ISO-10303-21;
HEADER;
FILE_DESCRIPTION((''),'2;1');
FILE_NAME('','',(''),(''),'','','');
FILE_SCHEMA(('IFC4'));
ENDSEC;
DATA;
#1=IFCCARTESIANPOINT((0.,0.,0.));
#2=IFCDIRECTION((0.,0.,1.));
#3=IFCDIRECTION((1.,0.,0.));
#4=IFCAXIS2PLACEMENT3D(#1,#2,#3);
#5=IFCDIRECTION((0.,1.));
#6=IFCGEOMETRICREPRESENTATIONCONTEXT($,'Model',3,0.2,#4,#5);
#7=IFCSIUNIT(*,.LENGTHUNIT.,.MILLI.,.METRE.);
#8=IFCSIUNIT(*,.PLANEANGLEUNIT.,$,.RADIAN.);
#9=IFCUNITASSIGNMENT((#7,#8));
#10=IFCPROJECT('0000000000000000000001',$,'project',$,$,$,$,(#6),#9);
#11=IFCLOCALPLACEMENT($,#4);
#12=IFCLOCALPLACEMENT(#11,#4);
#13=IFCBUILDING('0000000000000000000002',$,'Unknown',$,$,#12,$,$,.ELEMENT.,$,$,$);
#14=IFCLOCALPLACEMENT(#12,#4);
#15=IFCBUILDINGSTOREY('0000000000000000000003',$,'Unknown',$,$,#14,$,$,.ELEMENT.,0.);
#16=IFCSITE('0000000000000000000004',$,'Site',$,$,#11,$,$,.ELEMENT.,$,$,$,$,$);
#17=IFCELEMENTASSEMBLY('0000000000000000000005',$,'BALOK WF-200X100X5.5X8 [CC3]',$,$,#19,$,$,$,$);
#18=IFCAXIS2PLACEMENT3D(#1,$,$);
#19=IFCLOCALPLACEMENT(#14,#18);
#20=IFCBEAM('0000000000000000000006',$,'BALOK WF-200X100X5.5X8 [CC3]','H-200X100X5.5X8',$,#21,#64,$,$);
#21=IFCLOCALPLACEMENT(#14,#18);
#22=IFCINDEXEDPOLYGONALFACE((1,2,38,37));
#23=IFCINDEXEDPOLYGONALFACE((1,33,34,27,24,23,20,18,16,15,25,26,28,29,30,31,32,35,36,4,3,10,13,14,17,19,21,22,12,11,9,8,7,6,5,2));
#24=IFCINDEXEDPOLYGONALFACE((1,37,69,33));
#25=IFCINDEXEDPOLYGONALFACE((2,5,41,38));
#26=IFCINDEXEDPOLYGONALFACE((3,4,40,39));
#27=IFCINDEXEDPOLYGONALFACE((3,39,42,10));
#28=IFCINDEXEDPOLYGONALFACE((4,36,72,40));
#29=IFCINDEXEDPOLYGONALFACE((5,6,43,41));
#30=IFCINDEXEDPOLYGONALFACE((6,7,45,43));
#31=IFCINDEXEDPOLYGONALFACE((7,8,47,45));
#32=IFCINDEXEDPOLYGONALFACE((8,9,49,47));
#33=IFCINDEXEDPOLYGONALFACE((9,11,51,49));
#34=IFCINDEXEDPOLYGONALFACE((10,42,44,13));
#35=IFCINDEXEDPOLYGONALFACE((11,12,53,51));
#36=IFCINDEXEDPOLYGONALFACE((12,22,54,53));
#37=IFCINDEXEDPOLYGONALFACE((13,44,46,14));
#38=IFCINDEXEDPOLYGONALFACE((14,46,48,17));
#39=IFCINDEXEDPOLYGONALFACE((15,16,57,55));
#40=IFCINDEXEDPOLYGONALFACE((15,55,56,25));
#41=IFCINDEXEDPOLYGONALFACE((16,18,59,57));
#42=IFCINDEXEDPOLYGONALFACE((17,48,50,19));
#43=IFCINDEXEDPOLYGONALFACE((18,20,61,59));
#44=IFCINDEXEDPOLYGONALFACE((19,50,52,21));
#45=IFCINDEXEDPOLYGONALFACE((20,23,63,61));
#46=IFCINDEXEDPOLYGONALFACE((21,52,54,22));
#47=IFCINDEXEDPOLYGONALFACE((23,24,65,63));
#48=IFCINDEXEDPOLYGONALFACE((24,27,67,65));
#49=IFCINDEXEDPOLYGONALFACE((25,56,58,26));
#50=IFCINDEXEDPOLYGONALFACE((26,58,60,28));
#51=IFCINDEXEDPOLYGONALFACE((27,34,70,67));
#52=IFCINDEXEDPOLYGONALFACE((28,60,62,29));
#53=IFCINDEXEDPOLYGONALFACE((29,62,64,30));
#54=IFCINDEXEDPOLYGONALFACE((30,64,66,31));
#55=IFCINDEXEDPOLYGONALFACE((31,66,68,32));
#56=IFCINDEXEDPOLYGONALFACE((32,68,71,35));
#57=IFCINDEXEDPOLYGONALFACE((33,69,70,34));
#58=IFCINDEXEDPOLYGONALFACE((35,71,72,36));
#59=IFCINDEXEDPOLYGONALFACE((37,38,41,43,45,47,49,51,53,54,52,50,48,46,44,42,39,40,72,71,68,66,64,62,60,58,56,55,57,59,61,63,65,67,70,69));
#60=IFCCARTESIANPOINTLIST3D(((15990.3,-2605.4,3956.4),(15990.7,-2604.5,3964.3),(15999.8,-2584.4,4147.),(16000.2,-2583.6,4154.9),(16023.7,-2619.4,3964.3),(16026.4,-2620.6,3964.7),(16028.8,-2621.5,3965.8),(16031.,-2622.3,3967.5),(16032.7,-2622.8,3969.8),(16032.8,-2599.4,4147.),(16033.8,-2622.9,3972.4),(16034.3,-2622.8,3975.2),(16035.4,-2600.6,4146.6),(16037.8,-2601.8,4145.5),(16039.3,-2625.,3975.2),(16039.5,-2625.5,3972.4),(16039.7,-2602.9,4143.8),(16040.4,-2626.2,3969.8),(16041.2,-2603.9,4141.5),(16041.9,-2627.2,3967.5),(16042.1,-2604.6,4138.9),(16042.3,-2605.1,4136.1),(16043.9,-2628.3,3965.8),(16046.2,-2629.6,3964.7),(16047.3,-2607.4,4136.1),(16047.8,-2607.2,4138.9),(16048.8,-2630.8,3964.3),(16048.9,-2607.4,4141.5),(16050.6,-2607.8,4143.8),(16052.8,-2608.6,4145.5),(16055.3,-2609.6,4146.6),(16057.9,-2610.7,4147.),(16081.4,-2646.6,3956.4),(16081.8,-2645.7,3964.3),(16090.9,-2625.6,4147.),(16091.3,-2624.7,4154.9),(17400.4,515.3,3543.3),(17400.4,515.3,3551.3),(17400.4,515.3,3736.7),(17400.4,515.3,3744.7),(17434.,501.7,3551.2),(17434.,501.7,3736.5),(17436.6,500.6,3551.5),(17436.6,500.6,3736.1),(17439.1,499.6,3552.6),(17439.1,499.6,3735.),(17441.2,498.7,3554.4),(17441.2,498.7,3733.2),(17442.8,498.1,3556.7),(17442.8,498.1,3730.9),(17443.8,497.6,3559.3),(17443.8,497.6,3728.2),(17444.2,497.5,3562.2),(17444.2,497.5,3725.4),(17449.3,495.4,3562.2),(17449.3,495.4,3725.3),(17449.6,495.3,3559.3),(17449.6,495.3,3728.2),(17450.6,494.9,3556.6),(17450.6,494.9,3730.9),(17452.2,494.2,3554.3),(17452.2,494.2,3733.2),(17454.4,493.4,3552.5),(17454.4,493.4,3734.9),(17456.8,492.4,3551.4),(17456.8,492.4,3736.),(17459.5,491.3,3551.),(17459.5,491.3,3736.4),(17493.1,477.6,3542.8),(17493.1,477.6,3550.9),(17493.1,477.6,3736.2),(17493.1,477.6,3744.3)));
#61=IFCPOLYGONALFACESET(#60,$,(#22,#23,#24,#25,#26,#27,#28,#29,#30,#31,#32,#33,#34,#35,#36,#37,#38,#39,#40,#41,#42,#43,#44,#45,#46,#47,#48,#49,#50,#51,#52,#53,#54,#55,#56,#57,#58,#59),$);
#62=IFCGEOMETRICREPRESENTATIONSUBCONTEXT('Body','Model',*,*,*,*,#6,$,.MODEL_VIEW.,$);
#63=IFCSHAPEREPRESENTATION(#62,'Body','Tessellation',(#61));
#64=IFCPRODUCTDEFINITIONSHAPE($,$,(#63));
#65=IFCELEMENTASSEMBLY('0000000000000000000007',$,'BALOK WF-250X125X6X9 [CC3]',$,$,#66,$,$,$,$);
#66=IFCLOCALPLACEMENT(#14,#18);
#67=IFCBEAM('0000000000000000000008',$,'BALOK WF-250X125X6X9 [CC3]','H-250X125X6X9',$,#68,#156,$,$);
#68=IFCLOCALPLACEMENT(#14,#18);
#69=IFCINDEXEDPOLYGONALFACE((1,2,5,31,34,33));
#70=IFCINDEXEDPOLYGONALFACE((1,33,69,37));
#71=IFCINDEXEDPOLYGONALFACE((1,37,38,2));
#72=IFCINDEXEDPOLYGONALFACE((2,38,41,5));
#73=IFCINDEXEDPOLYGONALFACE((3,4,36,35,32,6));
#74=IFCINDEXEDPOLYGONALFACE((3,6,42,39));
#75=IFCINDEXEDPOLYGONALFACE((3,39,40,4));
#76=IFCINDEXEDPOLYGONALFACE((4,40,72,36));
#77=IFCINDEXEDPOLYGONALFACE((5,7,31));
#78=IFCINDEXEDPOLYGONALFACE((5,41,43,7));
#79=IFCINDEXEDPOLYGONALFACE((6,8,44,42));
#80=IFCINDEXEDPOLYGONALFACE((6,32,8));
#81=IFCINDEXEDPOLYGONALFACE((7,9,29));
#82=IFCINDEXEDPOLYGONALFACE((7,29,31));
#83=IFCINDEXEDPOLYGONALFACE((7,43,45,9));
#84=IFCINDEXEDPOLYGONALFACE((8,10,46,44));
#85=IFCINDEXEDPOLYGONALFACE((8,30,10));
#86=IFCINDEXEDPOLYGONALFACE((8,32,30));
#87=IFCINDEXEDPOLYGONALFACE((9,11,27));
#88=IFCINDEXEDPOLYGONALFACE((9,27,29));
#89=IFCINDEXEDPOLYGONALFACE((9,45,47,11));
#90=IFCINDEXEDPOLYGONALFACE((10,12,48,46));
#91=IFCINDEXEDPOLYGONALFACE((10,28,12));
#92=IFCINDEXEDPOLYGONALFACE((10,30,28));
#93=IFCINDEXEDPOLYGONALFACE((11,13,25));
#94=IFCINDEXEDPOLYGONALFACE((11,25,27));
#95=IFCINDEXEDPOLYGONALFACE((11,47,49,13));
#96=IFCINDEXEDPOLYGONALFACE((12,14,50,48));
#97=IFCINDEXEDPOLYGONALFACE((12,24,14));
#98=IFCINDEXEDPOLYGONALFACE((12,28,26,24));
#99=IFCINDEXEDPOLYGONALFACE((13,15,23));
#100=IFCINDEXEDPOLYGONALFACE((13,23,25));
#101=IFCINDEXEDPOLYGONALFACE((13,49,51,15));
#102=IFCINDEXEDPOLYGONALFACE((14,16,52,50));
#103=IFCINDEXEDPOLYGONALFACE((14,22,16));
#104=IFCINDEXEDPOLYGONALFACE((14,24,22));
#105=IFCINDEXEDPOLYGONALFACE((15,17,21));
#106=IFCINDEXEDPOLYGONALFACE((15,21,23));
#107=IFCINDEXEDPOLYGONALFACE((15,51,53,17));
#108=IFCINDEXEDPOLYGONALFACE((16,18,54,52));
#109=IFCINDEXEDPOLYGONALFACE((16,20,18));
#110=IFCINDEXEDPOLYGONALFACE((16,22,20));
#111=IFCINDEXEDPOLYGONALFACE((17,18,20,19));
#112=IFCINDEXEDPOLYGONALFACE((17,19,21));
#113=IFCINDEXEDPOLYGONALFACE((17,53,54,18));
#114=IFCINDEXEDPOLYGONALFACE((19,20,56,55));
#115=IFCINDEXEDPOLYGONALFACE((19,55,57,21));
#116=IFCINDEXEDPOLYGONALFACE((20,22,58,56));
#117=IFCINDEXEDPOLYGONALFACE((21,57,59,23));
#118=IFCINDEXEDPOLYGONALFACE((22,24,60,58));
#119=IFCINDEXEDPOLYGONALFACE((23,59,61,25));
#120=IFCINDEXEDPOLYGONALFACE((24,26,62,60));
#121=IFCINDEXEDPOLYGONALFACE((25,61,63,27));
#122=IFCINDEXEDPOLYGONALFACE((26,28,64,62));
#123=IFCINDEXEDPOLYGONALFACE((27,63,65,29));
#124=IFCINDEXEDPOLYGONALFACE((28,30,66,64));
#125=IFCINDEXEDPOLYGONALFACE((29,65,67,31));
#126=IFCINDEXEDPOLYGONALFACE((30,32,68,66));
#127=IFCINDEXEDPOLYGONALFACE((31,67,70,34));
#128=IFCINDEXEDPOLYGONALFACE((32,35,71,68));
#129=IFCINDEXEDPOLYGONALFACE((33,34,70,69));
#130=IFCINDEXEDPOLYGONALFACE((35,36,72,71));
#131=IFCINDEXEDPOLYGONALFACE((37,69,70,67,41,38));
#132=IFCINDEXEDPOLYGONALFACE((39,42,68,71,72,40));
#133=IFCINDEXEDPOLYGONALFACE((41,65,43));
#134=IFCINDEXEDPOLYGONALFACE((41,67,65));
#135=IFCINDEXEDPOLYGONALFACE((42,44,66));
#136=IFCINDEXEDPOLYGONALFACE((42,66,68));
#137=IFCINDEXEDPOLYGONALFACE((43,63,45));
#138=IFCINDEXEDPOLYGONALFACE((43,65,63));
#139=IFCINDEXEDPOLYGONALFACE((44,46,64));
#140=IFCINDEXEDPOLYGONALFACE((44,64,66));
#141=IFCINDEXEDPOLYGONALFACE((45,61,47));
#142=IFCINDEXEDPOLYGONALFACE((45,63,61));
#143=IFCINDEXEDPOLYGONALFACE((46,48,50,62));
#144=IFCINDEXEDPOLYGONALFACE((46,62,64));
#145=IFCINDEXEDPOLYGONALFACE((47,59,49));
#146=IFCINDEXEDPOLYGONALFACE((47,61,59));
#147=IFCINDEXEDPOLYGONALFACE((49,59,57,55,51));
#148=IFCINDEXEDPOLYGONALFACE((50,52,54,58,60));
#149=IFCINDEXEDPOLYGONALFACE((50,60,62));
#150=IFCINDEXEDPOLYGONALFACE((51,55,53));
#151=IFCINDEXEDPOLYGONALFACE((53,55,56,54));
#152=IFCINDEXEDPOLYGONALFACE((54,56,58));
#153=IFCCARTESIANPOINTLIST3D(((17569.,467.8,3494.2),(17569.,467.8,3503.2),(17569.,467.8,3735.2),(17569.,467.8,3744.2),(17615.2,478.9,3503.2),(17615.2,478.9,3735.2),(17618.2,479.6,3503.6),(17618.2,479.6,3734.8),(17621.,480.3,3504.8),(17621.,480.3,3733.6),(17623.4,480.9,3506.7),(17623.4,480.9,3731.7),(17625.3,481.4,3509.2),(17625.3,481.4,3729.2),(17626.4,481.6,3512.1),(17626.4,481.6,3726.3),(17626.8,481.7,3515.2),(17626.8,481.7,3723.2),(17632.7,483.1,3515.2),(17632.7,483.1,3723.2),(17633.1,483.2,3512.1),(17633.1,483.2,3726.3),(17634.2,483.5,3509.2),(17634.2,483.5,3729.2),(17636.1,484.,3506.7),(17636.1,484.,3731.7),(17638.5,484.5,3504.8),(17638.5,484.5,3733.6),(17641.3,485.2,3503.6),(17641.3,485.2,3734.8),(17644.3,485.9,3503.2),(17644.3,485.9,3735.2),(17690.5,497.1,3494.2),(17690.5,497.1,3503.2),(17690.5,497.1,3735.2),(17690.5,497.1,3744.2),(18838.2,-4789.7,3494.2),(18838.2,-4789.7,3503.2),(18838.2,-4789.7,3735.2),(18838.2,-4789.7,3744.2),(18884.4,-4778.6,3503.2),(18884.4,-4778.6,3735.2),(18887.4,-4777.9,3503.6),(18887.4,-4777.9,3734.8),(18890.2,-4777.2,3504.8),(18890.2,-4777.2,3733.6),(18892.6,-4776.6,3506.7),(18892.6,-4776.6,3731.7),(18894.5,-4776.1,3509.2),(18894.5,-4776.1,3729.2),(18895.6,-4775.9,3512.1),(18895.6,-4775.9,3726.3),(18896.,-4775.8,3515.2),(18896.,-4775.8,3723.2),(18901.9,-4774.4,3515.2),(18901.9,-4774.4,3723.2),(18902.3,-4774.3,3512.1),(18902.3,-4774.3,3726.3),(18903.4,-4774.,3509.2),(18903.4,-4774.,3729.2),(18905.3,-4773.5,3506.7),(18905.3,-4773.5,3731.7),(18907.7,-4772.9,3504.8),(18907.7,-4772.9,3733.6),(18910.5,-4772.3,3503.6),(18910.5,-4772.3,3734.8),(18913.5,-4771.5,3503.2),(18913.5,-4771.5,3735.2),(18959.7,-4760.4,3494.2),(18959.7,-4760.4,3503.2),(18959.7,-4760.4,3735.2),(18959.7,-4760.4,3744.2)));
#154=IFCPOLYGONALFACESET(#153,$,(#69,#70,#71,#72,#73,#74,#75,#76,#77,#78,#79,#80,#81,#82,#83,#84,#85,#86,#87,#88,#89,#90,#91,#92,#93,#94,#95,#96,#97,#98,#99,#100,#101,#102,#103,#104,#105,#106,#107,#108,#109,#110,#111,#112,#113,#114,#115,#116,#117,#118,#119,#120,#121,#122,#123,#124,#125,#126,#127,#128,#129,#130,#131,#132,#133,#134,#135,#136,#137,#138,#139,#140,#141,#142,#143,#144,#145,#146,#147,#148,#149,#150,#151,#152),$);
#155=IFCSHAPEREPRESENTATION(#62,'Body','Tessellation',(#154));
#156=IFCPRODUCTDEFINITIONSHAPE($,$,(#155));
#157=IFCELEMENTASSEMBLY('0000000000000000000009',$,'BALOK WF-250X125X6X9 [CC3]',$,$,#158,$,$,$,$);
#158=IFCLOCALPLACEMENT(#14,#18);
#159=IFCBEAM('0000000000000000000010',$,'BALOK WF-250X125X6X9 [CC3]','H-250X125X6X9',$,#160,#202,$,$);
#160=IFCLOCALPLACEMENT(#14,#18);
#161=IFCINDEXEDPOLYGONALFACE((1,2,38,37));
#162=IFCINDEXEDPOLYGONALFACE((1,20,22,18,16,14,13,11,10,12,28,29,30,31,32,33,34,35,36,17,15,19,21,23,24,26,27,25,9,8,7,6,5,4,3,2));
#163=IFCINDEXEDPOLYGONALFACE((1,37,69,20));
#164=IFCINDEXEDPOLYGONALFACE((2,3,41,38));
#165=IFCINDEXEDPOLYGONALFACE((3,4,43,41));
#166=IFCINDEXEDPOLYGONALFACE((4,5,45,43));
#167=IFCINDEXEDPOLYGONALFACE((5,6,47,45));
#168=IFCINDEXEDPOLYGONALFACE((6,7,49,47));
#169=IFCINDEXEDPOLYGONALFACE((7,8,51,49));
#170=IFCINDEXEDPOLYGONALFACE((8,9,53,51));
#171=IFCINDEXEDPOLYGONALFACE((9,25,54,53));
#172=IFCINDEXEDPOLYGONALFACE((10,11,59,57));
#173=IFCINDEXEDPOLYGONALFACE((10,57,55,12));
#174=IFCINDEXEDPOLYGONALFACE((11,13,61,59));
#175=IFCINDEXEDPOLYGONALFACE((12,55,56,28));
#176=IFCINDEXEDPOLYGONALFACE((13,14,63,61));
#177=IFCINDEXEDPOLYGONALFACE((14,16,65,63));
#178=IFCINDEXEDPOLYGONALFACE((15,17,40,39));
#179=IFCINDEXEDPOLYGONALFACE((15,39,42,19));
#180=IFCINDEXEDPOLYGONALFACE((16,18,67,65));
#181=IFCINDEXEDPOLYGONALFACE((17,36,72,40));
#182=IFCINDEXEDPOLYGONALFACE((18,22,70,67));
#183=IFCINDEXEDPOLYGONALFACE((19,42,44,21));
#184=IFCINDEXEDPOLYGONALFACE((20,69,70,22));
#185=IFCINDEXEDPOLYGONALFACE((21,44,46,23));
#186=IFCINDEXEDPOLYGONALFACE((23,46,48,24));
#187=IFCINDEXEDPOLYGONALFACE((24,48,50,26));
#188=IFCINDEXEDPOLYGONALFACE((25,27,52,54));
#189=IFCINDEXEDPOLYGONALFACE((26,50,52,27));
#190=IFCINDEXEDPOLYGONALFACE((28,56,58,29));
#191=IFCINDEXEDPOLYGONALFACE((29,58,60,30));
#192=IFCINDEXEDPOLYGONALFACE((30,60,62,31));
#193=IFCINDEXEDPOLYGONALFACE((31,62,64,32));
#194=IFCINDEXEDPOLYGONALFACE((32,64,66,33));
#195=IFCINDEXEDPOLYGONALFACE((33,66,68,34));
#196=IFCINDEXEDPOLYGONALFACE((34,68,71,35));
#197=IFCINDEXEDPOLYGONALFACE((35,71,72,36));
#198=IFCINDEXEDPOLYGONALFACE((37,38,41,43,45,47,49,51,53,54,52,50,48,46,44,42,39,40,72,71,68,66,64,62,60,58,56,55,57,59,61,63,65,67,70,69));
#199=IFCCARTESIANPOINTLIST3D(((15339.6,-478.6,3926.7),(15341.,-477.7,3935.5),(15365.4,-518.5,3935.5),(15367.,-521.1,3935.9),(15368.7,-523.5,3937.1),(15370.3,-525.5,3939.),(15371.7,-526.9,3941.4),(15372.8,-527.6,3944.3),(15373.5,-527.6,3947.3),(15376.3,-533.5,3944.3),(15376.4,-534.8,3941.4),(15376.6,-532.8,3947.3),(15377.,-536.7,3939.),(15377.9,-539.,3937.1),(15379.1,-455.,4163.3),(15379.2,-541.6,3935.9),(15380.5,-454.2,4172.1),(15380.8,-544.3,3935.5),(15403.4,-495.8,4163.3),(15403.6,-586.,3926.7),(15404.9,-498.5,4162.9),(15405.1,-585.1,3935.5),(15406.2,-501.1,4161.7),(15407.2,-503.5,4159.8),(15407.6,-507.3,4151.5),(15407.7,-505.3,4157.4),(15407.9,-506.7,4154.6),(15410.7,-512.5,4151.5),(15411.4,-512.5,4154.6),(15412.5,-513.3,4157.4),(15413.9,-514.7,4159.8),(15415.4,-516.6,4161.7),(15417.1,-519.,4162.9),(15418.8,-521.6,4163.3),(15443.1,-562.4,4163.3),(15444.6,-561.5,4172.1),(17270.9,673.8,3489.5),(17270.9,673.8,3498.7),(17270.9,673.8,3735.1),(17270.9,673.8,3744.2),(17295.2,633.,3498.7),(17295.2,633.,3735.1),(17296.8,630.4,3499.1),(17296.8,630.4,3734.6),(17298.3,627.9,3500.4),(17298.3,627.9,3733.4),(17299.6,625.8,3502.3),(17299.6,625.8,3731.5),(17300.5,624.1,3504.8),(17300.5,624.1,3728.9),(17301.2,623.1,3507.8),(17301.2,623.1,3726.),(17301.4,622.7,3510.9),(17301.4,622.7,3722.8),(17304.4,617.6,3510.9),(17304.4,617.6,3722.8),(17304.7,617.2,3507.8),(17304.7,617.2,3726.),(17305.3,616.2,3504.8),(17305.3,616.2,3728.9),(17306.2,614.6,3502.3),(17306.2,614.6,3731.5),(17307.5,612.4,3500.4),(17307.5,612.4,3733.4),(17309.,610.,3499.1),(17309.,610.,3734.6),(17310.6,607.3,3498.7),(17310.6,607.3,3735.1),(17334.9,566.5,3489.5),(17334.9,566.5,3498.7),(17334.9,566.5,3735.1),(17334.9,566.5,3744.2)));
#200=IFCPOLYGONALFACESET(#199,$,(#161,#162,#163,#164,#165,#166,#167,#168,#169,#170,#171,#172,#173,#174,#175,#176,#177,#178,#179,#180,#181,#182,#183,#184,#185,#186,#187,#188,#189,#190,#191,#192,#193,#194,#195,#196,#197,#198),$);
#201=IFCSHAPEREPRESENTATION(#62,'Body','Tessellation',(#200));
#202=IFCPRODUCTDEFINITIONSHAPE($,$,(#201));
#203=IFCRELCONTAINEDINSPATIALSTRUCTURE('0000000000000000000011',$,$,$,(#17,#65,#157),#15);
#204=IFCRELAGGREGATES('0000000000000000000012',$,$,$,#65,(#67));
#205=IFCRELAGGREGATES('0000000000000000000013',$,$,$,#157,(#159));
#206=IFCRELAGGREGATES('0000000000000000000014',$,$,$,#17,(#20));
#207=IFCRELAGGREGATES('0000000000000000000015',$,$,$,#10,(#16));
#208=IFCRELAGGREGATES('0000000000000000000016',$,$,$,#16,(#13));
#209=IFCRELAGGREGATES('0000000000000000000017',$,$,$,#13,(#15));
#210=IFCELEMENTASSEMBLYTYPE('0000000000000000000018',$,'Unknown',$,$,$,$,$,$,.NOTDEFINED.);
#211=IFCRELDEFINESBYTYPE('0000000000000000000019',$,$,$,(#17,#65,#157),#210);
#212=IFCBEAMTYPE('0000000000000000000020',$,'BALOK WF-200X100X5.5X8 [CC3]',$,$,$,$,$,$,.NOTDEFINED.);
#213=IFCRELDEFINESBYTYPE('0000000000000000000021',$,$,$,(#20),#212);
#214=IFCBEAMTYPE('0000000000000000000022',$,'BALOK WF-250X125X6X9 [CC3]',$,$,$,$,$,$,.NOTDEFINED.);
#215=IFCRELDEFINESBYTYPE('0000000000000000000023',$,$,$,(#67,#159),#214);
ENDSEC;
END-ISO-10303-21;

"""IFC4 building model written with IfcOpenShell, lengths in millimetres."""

from ifc_helpers import new_model, si_unit, direction, frame, origin_with_axes, origin_2d_with_axis, place, context, subcontext, project, spatial, i_section, extrude, clip, halfspace, type_object, element, aggregate, save


model = new_model("IFC4")

# Units and contexts
model_context = context("Model", 3, precision=0.2, world=origin_with_axes(), true_north=direction((0.0, 1.0)))
body_context = subcontext(model_context, "Body", "Model", "MODEL_VIEW")
ifc_project = project(units=[si_unit("LENGTHUNIT", "METRE", prefix="MILLI"), si_unit("PLANEANGLEUNIT", "RADIAN")], contexts=[model_context])

# Site, building, storey
site_placement = place(None, origin_with_axes())
site = spatial("IfcSite", under=ifc_project, at=site_placement, Name="Site", CompositionType="ELEMENT")
building_placement = place(site_placement, origin_with_axes())
building = spatial("IfcBuilding", under=site, at=building_placement, Name="Unknown", CompositionType="ELEMENT")
storey_placement = place(building_placement, origin_with_axes())
storey = spatial("IfcBuildingStorey", under=building, at=storey_placement, Name="Unknown", CompositionType="ELEMENT", Elevation=0.0)

# Element assemblies, beams
element_assembly_type = type_object("IfcElementAssemblyType", Name="Unknown", PredefinedType="NOTDEFINED")
assembly_1_placement = place(storey_placement, frame((17455.2, 515.3, 3641.3), z_axis=(0.911295, -0.411755, 0.0), x_axis=(-0.408792, -0.904736, 0.11976)))
assembly_1 = element("IfcElementAssembly", 1, at=assembly_1_placement, inside=storey, type_object=element_assembly_type, Name="BALOK WF-200X100X5.5X8 [CC3]")
beam_type_1 = type_object("IfcBeamType", Name="BALOK WF-200X100X5.5X8 [CC3]", PredefinedType="NOTDEFINED")
beam_1_placement = place(assembly_1_placement, origin_with_axes())
beam_1 = element("IfcBeam", 2, at=beam_1_placement, type_object=beam_type_1, Name="BALOK WF-200X100X5.5X8 [CC3]", Description="H-200X100X5.5X8", context=body_context, shape_type="Clipping", body=[
    clip(clip(extrude(i_section(OverallWidth=100.0, OverallDepth=200.0, WebThickness=5.5, FlangeThickness=8.0, FilletRadius=11.0, FlangeEdgeRadius=0.0, FlangeSlope=0.0, at=origin_2d_with_axis()), frame((0.0, 0.0, 0.0), z_axis=(-1.0, 0.0, 0.0), x_axis=(0.0, 0.0, 1.0)), (0.0, 0.0, -1.0), 3460.0), halfspace(frame((32.8, -100.0, -50.0), z_axis=(-0.992085, -0.119673, -0.038021), x_axis=(-0.038296, 0.0, 0.999266)), False)), halfspace(frame((34.8, -100.0, -50.0), z_axis=(-0.992085, -0.119673, -0.038021), x_axis=(-0.038296, 0.0, 0.999266)), False)),
])
assembly_2_placement = place(storey_placement, frame((17628.6, 487.2, 3619.2), z_axis=(-0.972076, -0.234666, 0.0), x_axis=(0.234666, -0.972076, 0.0)))
assembly_2 = element("IfcElementAssembly", 3, at=assembly_2_placement, inside=storey, type_object=element_assembly_type, Name="BALOK WF-250X125X6X9 [CC3]")
beam_type_2 = type_object("IfcBeamType", Name="BALOK WF-250X125X6X9 [CC3]", PredefinedType="NOTDEFINED")
beam_2_placement = place(assembly_2_placement, origin_with_axes())
beam_2 = element("IfcBeam", 4, at=beam_2_placement, type_object=beam_type_2, Name="BALOK WF-250X125X6X9 [CC3]", Description="H-250X125X6X9", context=body_context, shape_type="Clipping", body=[
    clip(clip(clip(clip(extrude(i_section(OverallWidth=125.0, OverallDepth=250.0, WebThickness=6.0, FlangeThickness=9.0, FilletRadius=12.0, FlangeEdgeRadius=0.0, FlangeSlope=0.0, at=origin_2d_with_axis()), frame((0.0, 0.0, 0.0), z_axis=(-1.0, 0.0, 0.0), x_axis=(0.0, 0.0, 1.0)), (0.0, 0.0, -1.0), 5418.4), halfspace(frame((3.0, -125.0, -62.5), z_axis=(-1.0, 0.0, -0.000281), x_axis=(-0.000281, 0.0, 1.0)), False)), halfspace(frame((5415.5, -125.0, 62.5), z_axis=(1.0, 0.0, 0.0), x_axis=(0.0, 0.0, -1.0)), False)), halfspace(frame((5.0, -125.0, -62.5), z_axis=(-1.0, 0.0, -0.000351), x_axis=(-0.000351, 0.0, 1.0)), False)), halfspace(frame((5413.5, -125.0, 62.5), z_axis=(1.0, 0.0, -0.000132), x_axis=(-0.000132, 0.0, -1.0)), False)),
])
assembly_3_placement = place(storey_placement, frame((17330.9, 636.9, 3610.6), z_axis=(-0.512421, 0.858734, 0.0), x_axis=(-0.842957, -0.503007, 0.190809)))
assembly_3 = element("IfcElementAssembly", 5, at=assembly_3_placement, inside=storey, type_object=element_assembly_type, Name="BALOK WF-250X125X6X9 [CC3]")
beam_3_placement = place(assembly_3_placement, origin_with_axes())
beam_3 = element("IfcBeam", 6, at=beam_3_placement, type_object=beam_type_2, Name="BALOK WF-250X125X6X9 [CC3]", Description="H-250X125X6X9", context=body_context, shape_type="Clipping", body=[
    clip(clip(extrude(i_section(OverallWidth=125.0, OverallDepth=250.0, WebThickness=6.0, FlangeThickness=9.0, FilletRadius=12.0, FlangeEdgeRadius=0.0, FlangeSlope=0.0, at=origin_2d_with_axis()), frame((0.0, 0.0, 0.0), z_axis=(-1.0, 0.0, 0.0), x_axis=(0.0, 0.0, 1.0)), (0.0, 0.0, -1.0), 2300.0), halfspace(frame((6.8, -125.0, -62.5), z_axis=(-0.981627, 0.190809, 0.000117), x_axis=(0.000119, 0.0, 1.0)), False)), halfspace(frame((8.9, -125.0, -62.5), z_axis=(-0.981627, 0.190809, -0.000119), x_axis=(-0.000121, 0.0, 1.0)), False)),
])

aggregate(assembly_2, [beam_2])
aggregate(assembly_3, [beam_3])

aggregate(assembly_1, [beam_1])

save(model, "model.ifc")
